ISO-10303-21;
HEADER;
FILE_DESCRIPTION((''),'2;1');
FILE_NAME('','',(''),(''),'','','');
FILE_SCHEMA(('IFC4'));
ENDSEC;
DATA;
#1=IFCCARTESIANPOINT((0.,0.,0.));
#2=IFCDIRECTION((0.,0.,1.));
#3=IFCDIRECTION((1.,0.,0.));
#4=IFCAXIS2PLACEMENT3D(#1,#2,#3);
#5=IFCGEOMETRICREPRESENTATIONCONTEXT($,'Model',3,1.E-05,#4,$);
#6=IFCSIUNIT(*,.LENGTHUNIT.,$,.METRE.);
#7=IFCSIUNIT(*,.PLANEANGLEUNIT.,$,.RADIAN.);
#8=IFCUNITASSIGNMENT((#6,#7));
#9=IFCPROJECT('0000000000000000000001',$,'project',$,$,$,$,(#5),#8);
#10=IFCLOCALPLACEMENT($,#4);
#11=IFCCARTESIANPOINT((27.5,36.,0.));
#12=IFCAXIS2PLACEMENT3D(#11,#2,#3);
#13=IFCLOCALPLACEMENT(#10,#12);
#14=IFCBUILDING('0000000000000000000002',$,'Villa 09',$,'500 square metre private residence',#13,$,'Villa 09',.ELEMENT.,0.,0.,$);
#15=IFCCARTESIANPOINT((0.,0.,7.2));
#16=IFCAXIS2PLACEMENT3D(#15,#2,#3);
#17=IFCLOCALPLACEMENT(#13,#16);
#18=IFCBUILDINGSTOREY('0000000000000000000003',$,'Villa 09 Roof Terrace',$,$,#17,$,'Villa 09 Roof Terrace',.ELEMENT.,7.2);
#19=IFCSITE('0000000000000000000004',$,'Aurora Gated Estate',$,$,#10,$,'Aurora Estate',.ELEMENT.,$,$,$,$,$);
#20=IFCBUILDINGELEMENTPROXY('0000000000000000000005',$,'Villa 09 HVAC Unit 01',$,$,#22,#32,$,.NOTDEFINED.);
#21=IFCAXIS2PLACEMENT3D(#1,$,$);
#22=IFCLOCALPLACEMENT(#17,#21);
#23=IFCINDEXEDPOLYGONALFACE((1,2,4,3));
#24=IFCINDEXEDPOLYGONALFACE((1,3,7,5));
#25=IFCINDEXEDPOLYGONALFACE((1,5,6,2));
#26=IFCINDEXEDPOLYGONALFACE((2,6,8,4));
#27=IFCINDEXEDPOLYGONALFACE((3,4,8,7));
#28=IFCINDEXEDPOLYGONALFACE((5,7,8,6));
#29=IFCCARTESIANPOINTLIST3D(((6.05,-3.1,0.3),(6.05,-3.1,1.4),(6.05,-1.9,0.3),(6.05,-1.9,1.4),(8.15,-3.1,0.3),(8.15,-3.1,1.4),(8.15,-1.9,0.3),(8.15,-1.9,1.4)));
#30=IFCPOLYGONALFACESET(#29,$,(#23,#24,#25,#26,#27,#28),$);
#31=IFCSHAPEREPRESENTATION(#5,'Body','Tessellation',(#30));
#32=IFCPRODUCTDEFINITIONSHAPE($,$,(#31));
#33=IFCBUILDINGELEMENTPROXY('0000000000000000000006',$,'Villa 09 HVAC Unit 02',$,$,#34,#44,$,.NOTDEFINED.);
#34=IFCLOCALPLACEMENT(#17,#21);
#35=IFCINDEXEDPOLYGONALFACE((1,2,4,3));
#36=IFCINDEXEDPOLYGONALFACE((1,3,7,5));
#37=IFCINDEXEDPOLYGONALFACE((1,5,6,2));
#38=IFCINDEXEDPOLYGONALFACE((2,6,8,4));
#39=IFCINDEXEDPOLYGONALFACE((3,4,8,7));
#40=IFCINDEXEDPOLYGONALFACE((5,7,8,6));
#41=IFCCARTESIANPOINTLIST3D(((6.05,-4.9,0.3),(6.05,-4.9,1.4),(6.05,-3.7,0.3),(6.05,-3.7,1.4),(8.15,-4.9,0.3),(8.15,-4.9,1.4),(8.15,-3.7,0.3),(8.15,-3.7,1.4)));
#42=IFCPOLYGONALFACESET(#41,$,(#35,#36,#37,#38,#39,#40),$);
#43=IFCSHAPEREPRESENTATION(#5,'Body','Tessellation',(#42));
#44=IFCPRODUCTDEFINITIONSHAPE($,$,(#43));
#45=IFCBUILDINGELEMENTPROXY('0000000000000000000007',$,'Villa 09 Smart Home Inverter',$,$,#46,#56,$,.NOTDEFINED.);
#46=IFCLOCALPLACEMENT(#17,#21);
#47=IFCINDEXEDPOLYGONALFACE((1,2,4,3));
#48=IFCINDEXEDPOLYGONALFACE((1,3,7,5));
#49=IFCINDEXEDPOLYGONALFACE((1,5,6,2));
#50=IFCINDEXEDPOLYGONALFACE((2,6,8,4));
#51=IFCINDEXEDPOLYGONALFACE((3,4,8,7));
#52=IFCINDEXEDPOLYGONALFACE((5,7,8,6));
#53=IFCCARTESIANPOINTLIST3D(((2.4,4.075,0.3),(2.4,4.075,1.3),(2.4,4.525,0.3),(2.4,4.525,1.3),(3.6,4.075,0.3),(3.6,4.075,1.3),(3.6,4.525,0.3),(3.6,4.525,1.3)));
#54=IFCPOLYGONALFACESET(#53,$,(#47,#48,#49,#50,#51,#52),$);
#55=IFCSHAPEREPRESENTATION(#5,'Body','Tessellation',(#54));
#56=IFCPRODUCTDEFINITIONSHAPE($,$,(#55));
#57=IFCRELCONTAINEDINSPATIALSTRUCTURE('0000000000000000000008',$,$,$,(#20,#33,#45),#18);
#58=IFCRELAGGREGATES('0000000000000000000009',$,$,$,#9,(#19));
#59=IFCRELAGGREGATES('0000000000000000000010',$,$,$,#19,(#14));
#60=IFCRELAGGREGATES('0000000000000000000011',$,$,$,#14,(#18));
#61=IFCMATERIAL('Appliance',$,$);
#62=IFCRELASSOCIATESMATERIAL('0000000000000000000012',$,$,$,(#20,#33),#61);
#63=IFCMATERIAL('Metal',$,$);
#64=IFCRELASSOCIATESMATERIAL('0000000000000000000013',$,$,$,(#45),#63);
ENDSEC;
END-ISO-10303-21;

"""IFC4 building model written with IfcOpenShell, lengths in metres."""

from ifc_helpers import new_model, si_unit, frame, origin_with_axes, origin_2d_with_axis, place, context, project, spatial, rectangle, extrude, material, element, save


model = new_model("IFC4")

# Units and contexts
model_context = context("Model", 3, precision=1e-05, world=origin_with_axes())
ifc_project = project(units=[si_unit("LENGTHUNIT", "METRE"), si_unit("PLANEANGLEUNIT", "RADIAN")], contexts=[model_context])

# Site, building, storey
site_placement = place(None, origin_with_axes())
site = spatial("IfcSite", under=ifc_project, at=site_placement, Name="Aurora Gated Estate", LongName="Aurora Estate", CompositionType="ELEMENT")
building_placement = place(site_placement, frame((27.5, 36.0, 0.0), z_axis=(0.0, 0.0, 1.0), x_axis=(1.0, 0.0, 0.0)))
building = spatial("IfcBuilding", under=site, at=building_placement, Name="Villa 09", ObjectType="500 square metre private residence", LongName="Villa 09", CompositionType="ELEMENT", ElevationOfRefHeight=0.0, ElevationOfTerrain=0.0)
storey_placement = place(building_placement, frame((0.0, 0.0, 7.2), z_axis=(0.0, 0.0, 1.0), x_axis=(1.0, 0.0, 0.0)))
storey = spatial("IfcBuildingStorey", under=building, at=storey_placement, Name="Villa 09 Roof Terrace", LongName="Villa 09 Roof Terrace", CompositionType="ELEMENT", Elevation=7.2)

# Building element proxies
ifc_material_1 = material(Name="Metal")
ifc_material_2 = material(Name="Appliance")
for number, where, z_axis, x_axis, name in (
    (1, (7.1, -2.5, 0.3), (0.0, 0.0, 1.0), (1.0, 0.0, 0.0), "Villa 09 HVAC Unit 01"),
    (2, (7.1, -4.3, 0.3), (0.0, 0.0, 1.0), (1.0, 0.0, 0.0), "Villa 09 HVAC Unit 02"),
):
    element("IfcBuildingElementProxy", number, at=place(storey_placement, frame(where, z_axis=z_axis, x_axis=x_axis)), inside=storey, material=ifc_material_2, Name=name, PredefinedType="NOTDEFINED", context=model_context, shape_type="SweptSolid", body=[
        extrude(rectangle(XDim=2.1, YDim=1.2, at=origin_2d_with_axis()), origin_with_axes(), (0.0, 0.0, 1.0), 1.1),
    ])
proxy_1_placement = place(storey_placement, frame((3.0, 4.3, 0.3), z_axis=(0.0, 0.0, 1.0), x_axis=(1.0, 0.0, 0.0)))
element("IfcBuildingElementProxy", 3, at=proxy_1_placement, inside=storey, material=ifc_material_1, Name="Villa 09 Smart Home Inverter", PredefinedType="NOTDEFINED", context=model_context, shape_type="SweptSolid", body=[
    extrude(rectangle(XDim=1.2, YDim=0.45, at=origin_2d_with_axis()), origin_with_axes(), (0.0, 0.0, 1.0), 1.0),
])

save(model, "model.ifc")
